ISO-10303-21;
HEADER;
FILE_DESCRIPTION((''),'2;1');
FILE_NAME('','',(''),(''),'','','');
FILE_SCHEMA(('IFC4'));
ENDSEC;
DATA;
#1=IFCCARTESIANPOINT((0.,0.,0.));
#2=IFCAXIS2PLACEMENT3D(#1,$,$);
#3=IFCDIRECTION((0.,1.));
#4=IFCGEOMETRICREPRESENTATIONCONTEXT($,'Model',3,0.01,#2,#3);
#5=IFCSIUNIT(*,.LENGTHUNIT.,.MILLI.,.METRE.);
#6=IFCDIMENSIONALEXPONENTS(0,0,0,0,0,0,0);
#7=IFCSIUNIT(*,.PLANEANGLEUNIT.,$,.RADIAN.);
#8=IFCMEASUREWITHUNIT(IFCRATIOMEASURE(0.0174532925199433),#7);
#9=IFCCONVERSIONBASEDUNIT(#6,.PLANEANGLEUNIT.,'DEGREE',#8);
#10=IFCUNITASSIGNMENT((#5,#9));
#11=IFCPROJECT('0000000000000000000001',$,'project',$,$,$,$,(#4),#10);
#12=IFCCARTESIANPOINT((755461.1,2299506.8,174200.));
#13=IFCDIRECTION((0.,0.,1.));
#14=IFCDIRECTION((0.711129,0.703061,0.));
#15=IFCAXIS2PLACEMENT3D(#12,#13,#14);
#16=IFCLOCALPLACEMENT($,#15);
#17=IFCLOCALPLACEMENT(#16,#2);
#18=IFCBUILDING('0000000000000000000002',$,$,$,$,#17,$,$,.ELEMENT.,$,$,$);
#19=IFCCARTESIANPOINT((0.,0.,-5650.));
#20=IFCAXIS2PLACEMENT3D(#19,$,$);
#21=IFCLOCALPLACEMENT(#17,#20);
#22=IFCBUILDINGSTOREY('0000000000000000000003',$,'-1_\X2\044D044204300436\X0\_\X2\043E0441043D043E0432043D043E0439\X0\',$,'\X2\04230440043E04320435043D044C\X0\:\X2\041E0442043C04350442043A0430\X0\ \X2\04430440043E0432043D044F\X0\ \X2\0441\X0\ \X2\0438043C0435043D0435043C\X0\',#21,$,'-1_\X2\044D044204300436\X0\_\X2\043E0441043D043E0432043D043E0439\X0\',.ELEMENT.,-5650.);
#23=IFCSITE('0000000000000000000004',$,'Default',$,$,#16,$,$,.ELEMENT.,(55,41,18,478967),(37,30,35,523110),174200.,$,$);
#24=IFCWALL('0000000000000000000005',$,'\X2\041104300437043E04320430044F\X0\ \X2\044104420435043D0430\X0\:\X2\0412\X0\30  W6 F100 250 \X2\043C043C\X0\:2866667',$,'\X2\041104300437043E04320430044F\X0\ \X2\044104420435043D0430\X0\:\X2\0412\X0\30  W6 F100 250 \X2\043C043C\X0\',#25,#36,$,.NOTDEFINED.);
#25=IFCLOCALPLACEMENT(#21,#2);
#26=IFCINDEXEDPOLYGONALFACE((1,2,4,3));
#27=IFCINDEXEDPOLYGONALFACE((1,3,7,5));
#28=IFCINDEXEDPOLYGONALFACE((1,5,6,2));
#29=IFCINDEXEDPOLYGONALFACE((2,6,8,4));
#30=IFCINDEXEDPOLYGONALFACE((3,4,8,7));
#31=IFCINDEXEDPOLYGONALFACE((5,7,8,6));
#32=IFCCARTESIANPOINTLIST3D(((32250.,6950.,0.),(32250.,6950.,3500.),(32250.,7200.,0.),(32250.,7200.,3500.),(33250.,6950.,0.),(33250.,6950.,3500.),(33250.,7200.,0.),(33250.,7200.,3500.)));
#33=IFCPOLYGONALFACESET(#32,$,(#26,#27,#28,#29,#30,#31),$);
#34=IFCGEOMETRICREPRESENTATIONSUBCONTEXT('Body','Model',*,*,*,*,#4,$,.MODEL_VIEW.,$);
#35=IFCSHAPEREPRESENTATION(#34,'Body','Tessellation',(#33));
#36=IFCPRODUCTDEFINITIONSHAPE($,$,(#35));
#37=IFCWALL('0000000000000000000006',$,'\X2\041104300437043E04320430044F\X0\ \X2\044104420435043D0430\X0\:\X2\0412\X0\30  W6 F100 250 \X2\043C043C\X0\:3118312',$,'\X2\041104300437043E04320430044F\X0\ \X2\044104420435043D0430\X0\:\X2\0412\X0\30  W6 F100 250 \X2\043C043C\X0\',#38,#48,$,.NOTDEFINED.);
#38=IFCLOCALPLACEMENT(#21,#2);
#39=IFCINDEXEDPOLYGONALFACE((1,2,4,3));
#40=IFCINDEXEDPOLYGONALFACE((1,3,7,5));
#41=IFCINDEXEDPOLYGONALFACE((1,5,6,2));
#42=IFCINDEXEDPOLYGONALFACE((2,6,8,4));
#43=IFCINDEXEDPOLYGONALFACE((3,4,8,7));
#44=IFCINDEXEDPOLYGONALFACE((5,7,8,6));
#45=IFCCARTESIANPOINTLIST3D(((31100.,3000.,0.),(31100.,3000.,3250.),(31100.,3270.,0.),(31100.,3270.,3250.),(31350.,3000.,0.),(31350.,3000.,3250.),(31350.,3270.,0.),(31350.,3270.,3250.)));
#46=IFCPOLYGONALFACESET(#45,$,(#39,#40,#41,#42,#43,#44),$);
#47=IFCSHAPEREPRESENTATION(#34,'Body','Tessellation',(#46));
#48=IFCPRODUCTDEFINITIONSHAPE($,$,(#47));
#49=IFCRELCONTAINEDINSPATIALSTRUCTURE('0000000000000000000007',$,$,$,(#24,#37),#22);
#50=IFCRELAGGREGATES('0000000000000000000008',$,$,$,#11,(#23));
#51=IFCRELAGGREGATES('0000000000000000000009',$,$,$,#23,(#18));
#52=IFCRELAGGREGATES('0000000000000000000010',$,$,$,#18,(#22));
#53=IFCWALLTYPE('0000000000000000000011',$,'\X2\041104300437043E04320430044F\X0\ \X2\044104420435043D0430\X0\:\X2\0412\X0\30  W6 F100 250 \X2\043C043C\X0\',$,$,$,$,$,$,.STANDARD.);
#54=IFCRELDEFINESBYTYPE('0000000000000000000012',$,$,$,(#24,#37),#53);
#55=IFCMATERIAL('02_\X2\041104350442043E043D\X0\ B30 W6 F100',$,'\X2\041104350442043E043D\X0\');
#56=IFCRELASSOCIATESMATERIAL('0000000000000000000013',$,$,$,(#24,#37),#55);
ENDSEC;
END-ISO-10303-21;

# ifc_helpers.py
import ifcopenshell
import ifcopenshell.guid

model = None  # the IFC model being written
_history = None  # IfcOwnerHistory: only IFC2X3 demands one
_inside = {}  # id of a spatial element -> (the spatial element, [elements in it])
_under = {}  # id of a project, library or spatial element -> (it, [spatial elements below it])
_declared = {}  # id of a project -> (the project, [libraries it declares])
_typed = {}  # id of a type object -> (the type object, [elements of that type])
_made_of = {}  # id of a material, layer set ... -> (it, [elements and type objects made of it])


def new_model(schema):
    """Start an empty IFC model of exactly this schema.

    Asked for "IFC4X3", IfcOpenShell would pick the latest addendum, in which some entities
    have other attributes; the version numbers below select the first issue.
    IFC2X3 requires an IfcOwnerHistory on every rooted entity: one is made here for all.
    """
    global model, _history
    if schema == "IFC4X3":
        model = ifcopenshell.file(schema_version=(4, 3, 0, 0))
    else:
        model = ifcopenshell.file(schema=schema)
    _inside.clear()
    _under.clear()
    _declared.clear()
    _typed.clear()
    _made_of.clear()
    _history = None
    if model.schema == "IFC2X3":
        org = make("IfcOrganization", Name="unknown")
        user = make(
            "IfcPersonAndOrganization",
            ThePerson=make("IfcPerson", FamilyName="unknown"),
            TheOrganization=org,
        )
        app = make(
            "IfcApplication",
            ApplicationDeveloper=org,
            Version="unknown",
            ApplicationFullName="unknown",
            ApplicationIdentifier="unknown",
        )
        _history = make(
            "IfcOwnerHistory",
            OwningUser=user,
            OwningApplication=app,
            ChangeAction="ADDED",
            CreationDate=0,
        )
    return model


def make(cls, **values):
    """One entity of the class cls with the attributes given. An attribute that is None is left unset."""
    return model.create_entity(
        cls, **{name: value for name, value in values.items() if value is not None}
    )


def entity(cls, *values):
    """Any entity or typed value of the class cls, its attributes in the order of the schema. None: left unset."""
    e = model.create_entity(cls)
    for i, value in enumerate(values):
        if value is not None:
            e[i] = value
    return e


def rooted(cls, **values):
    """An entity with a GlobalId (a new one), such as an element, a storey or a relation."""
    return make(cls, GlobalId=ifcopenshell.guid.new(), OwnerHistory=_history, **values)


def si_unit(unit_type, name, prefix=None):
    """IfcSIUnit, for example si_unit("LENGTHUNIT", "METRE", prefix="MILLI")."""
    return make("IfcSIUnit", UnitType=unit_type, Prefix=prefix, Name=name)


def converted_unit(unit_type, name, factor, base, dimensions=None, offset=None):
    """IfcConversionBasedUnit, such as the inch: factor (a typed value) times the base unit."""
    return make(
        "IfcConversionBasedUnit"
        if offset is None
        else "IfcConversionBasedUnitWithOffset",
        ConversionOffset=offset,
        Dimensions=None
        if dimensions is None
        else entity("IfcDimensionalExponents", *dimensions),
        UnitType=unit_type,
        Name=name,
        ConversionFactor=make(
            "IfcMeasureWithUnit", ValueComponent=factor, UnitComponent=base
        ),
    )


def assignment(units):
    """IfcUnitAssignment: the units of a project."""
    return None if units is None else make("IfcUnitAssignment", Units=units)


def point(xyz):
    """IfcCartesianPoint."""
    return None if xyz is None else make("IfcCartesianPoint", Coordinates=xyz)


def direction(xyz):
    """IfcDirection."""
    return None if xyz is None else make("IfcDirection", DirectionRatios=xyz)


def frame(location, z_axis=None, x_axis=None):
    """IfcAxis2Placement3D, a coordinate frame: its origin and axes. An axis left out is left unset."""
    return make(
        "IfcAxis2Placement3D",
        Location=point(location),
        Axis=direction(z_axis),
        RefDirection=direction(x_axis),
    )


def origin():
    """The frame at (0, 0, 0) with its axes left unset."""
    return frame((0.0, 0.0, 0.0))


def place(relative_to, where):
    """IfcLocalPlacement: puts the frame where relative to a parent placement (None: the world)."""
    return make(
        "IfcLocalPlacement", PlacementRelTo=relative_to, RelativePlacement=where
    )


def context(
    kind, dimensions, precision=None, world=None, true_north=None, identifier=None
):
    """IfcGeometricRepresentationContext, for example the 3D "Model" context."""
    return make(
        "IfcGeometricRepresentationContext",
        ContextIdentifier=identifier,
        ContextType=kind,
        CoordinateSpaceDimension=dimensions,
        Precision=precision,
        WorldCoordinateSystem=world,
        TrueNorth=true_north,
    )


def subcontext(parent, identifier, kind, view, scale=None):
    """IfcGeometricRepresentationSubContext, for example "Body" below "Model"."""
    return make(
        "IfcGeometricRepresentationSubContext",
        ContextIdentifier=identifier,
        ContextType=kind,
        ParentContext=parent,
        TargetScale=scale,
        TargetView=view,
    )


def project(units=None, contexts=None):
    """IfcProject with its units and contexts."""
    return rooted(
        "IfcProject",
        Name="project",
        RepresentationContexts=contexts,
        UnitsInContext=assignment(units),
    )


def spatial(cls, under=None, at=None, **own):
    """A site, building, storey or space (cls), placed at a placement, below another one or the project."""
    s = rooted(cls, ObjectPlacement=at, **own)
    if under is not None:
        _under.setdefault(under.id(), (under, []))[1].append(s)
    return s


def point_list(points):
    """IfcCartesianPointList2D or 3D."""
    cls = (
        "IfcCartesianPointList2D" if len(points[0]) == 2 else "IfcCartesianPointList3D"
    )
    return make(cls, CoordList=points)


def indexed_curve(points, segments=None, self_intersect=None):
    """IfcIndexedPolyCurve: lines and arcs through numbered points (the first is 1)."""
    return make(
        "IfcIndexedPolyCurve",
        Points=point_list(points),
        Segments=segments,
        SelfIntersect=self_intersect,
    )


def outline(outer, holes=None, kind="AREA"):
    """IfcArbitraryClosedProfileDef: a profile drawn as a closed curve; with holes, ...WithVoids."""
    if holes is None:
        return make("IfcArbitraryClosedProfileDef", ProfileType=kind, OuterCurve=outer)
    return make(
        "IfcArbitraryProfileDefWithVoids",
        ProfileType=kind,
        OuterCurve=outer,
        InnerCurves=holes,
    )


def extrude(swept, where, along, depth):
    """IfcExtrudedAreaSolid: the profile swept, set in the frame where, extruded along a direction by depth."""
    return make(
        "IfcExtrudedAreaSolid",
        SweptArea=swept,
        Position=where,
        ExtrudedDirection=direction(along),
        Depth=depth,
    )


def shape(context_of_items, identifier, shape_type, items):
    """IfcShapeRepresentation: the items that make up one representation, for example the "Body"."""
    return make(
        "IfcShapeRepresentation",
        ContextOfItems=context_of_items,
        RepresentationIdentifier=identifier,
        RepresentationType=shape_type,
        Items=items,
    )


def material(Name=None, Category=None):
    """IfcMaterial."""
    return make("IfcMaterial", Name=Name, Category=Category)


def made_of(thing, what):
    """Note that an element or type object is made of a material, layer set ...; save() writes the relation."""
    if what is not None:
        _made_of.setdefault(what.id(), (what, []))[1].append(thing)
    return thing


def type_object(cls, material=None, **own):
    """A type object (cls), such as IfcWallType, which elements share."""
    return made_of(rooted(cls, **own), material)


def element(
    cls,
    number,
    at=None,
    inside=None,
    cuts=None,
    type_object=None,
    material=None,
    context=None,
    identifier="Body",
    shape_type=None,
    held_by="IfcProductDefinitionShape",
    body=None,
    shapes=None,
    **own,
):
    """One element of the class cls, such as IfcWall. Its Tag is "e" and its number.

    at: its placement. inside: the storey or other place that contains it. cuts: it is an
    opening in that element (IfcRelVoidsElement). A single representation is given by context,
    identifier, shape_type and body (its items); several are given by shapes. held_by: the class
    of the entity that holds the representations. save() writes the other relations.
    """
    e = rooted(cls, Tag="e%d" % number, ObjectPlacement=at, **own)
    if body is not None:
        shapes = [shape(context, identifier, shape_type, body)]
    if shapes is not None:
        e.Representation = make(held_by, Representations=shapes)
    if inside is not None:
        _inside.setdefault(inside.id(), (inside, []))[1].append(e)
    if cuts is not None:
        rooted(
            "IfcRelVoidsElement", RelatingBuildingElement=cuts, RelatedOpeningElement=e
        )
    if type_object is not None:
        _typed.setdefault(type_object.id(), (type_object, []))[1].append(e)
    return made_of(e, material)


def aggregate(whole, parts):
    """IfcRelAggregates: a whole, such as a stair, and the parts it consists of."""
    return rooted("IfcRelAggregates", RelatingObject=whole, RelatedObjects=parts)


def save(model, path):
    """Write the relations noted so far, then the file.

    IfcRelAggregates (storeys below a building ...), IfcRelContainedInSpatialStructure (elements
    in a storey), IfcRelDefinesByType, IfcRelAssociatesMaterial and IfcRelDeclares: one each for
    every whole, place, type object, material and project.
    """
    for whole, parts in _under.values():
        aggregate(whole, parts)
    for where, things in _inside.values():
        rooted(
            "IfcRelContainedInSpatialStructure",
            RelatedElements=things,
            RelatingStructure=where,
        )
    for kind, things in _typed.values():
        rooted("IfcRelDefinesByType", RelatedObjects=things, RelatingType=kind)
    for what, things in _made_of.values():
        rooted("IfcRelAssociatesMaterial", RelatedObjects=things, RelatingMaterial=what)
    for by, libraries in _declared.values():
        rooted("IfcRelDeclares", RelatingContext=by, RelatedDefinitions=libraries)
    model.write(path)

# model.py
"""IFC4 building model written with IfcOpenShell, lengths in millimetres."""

from ifc_helpers import new_model, entity, si_unit, converted_unit, direction, frame, origin, place, context, subcontext, project, spatial, indexed_curve, outline, extrude, material, type_object, element, save


model = new_model("IFC4")

# Units and contexts
model_context = context("Model", 3, precision=0.01, world=origin(), true_north=direction((0.0, 1.0)))
body_context = subcontext(model_context, "Body", "Model", "MODEL_VIEW")
ifc_project = project(units=[si_unit("LENGTHUNIT", "METRE", prefix="MILLI"), converted_unit("PLANEANGLEUNIT", "DEGREE", entity("IfcRatioMeasure", 0.0174532925199433), si_unit("PLANEANGLEUNIT", "RADIAN"), dimensions=[0, 0, 0, 0, 0, 0, 0])], contexts=[model_context])

# Site, building, storey
site_placement = place(None, frame((755461.1, 2299506.8, 174200.0), z_axis=(0.0, 0.0, 1.0), x_axis=(0.711129, 0.703061, 0.0)))
site = spatial("IfcSite", under=ifc_project, at=site_placement, Name="Default", CompositionType="ELEMENT", RefLatitude=(55, 41, 18, 478967), RefLongitude=(37, 30, 35, 523110), RefElevation=174200.0)
building_placement = place(site_placement, origin())
building = spatial("IfcBuilding", under=site, at=building_placement, CompositionType="ELEMENT")
storey_placement = place(building_placement, frame((0.0, 0.0, -5650.0)))
storey = spatial("IfcBuildingStorey", under=building, at=storey_placement, Name="-1_этаж_основной", ObjectType="Уровень:Отметка уровня с именем", LongName="-1_этаж_основной", CompositionType="ELEMENT", Elevation=-5650.0)

# Shared definitions
ifc_material_1 = material(Name="02_Бетон B30 W6 F100", Category="Бетон")

# Walls
wall_type = type_object("IfcWallType", Name="Базовая стена:В30  W6 F100 250 мм", PredefinedType="STANDARD")
wall_1_placement = place(storey_placement, frame((32250.0, 7075.0, 0.0)))
element("IfcWall", 1, at=wall_1_placement, inside=storey, type_object=wall_type, material=ifc_material_1, Name="Базовая стена:В30  W6 F100 250 мм:2866667", ObjectType="Базовая стена:В30  W6 F100 250 мм", PredefinedType="NOTDEFINED", context=body_context, shape_type="SweptSolid", body=[
    extrude(outline(indexed_curve([(1000.0, 125.0), (0.0, 125.0), (0.0, -125.0), (1000.0, -125.0), (1000.0, 125.0)], self_intersect=False)), origin(), (0.0, 0.0, 1.0), 3500.0),
])
wall_2_placement = place(storey_placement, frame((31225.0, 3000.0, 0.0), z_axis=(0.0, 0.0, 1.0), x_axis=(0.0, 1.0, 0.0)))
element("IfcWall", 2, at=wall_2_placement, inside=storey, type_object=wall_type, material=ifc_material_1, Name="Базовая стена:В30  W6 F100 250 мм:3118312", ObjectType="Базовая стена:В30  W6 F100 250 мм", PredefinedType="NOTDEFINED", context=body_context, shape_type="SweptSolid", body=[
    extrude(outline(indexed_curve([(270.0, 125.0), (0.0, 125.0), (0.0, -125.0), (270.0, -125.0), (270.0, 125.0)], self_intersect=False)), origin(), (0.0, 0.0, 1.0), 3250.0),
])

save(model, "model.ifc")
